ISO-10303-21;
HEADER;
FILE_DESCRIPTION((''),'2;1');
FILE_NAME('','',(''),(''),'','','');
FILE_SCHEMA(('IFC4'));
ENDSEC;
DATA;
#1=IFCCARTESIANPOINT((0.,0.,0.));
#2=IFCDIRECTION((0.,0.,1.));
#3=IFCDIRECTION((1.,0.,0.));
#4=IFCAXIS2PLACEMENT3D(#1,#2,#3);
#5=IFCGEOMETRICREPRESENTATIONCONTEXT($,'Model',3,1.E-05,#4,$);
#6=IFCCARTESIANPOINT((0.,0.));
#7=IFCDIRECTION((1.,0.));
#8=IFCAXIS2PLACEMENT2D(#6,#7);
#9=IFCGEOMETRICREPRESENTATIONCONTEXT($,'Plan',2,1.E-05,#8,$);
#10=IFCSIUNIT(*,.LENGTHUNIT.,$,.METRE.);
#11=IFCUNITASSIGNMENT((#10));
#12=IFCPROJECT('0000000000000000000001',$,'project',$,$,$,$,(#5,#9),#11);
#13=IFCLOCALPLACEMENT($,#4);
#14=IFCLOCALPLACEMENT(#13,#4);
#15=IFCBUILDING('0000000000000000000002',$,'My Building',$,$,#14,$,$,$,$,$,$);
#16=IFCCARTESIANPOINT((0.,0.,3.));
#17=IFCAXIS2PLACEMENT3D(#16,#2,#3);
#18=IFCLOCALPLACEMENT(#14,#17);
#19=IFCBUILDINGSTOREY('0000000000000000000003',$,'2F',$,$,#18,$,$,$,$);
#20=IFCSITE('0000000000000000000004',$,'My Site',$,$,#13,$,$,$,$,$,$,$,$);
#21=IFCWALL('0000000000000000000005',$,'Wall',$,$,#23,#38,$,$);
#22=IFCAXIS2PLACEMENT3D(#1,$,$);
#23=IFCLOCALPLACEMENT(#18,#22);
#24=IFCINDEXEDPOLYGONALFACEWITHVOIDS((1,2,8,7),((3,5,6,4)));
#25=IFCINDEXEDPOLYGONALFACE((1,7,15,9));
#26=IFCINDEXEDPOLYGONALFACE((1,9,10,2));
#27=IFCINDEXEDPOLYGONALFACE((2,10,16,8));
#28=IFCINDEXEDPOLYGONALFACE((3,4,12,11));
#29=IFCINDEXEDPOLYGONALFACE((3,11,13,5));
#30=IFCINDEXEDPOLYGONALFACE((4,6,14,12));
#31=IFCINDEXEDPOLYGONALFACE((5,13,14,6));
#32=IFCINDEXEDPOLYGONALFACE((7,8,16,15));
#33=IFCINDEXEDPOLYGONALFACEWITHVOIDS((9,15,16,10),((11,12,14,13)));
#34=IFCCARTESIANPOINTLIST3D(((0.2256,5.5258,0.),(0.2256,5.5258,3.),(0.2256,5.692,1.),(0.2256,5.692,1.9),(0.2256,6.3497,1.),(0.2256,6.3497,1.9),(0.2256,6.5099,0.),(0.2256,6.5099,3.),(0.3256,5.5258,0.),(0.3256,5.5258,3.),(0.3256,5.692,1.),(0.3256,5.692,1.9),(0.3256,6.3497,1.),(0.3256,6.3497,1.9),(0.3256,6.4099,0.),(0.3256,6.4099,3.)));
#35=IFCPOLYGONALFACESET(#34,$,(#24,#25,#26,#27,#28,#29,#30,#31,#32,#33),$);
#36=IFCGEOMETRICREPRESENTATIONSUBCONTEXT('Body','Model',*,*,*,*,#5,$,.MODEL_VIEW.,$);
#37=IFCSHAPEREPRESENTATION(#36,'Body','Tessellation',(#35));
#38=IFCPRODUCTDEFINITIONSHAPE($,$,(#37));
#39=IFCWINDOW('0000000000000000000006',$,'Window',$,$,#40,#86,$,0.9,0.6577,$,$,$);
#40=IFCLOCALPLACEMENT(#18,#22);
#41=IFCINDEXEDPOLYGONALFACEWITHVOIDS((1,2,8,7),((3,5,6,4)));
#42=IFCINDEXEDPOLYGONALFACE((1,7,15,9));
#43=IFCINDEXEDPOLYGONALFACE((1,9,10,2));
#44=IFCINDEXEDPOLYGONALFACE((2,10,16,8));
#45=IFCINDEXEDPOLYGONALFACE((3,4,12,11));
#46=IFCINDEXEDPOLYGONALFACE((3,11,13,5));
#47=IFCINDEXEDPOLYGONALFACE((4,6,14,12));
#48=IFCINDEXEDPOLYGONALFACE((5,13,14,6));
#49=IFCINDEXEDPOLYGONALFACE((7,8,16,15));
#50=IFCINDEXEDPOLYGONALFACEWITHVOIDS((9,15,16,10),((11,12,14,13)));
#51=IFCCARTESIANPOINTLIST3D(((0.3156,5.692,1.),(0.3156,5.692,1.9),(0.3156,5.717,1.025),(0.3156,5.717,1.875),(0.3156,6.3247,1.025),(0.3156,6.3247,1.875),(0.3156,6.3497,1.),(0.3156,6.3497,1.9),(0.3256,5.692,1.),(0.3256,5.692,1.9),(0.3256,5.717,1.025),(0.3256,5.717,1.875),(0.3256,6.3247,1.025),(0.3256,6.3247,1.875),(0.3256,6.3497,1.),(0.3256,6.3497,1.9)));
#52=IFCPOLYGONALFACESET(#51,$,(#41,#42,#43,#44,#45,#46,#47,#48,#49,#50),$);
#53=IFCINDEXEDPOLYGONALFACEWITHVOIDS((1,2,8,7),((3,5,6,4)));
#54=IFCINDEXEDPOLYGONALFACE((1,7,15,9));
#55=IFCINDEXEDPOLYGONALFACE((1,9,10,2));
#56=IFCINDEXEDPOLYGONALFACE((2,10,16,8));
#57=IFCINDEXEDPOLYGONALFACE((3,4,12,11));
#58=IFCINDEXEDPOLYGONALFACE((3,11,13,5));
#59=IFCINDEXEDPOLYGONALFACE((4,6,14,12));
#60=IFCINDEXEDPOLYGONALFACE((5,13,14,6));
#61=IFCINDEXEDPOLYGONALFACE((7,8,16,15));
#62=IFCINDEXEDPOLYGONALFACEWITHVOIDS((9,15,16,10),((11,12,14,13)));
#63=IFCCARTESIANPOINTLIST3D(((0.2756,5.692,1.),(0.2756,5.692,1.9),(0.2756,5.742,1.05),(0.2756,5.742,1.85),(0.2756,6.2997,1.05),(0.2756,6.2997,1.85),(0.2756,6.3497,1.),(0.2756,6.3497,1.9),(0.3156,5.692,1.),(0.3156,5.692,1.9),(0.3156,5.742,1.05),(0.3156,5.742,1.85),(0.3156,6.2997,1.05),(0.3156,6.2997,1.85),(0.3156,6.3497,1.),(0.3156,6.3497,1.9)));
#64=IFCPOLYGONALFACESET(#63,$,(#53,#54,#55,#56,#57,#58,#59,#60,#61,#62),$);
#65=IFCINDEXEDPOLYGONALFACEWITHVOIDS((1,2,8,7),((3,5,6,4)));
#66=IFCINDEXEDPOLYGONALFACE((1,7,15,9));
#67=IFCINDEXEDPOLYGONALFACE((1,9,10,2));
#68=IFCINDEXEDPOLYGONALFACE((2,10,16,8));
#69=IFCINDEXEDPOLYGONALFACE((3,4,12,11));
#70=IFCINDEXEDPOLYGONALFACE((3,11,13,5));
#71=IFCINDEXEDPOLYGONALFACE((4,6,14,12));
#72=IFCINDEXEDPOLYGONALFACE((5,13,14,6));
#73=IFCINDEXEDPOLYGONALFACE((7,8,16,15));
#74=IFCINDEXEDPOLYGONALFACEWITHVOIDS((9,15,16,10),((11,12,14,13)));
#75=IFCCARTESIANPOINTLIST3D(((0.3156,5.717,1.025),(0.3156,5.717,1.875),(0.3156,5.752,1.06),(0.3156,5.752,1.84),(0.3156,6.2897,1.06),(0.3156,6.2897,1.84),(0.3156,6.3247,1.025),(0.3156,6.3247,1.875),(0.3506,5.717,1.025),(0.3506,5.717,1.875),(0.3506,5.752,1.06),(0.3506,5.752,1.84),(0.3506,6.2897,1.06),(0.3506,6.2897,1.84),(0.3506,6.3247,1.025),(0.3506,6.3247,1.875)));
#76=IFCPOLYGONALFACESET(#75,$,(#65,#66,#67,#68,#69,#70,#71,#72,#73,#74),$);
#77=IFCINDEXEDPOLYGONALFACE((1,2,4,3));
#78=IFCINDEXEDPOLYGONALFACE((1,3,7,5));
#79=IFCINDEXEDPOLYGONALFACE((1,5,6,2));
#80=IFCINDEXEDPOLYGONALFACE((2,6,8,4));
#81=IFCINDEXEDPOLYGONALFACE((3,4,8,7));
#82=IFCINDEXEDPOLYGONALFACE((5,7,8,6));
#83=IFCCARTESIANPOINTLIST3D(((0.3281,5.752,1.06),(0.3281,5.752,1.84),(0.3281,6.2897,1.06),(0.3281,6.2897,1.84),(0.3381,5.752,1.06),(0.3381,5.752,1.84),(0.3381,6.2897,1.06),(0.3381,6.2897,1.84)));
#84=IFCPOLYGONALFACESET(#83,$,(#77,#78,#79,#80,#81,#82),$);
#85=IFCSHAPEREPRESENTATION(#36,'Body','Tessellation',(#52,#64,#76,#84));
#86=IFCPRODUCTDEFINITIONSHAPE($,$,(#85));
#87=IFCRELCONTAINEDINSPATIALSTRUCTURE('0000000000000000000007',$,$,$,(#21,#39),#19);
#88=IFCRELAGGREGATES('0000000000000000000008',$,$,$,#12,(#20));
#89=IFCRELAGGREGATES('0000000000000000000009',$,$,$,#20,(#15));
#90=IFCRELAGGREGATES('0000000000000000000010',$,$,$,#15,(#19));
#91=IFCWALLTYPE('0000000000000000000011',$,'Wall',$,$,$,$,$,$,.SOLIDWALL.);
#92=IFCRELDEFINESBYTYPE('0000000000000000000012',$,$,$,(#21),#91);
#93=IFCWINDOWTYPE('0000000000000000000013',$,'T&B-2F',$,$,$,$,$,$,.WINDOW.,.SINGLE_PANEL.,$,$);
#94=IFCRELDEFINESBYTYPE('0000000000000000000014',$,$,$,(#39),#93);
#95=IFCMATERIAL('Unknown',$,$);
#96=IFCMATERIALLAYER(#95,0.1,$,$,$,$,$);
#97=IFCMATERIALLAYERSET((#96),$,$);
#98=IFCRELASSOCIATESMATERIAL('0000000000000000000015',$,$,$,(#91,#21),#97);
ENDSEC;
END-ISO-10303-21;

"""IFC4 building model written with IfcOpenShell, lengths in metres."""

from ifc_helpers import new_model, entity, si_unit, frame, origin_with_axes, origin_2d_with_axis, place, context, subcontext, project, spatial, line, indexed_curve, outline, extrude, shape, source, transform, mapped, material, layer, layer_set, layer_usage, type_object, type_shapes, element, fill, save


model = new_model("IFC4")

# Units and contexts
model_context = context("Model", 3, precision=1e-05, world=origin_with_axes())
plan_context = context("Plan", 2, precision=1e-05, world=origin_2d_with_axis())
body_context_1 = subcontext(model_context, "Body", "Model", "MODEL_VIEW")
body_context_2 = subcontext(plan_context, "Body", "Plan", "PLAN_VIEW")
ifc_project = project(units=[si_unit("LENGTHUNIT", "METRE")], contexts=[model_context, plan_context])

# Site, building, storey
site_placement = place(None, origin_with_axes())
site = spatial("IfcSite", under=ifc_project, at=site_placement, Name="My Site")
building_placement = place(site_placement, origin_with_axes())
building = spatial("IfcBuilding", under=site, at=building_placement, Name="My Building")
storey_placement = place(building_placement, frame((0.0, 0.0, 3.0), z_axis=(0.0, 0.0, 1.0), x_axis=(1.0, 0.0, 0.0)))
storey = spatial("IfcBuildingStorey", under=building, at=storey_placement, Name="2F")

# Shared definitions
ifc_material = material(Name="Unknown")

# Shared definitions
ifc_layer = layer(ifc_material, 0.1)
ifc_layer_set = layer_set([ifc_layer])
wall_type = type_object("IfcWallType", Name="Wall", PredefinedType="SOLIDWALL", material=ifc_layer_set)

# Wall, opening, window
ifc_layer_usage_1 = layer_usage(ifc_layer_set, "AXIS2", "POSITIVE", 0.0)
wall_1_placement = place(storey_placement, frame((0.2256, 6.5099, 0.0), z_axis=(0.0, 0.0, 1.0), x_axis=(0.0, -1.0, 0.0)))
wall_1 = element("IfcWall", 1, at=wall_1_placement, inside=storey, type_object=wall_type, material=ifc_layer_usage_1, Name="Wall", context=body_context_1, shape_type="SweptSolid", body=[
    extrude(outline(indexed_curve([(0.0, 0.0), (0.1, 0.1), (0.9842, 0.1), (0.9842, 0.0)], segments=[line(1, 2, 3, 4, 1)])), origin_with_axes(), (0.0, 0.0, 1.0), 3.0),
])
shared_shape_1 = source(origin_with_axes(), body_context_1, "Body", "SweptSolid", [
    extrude(outline(indexed_curve([(0.0, 0.0), (0.6577, 0.0), (0.6577, 0.9), (0.0, 0.9)], segments=[line(1, 2, 3, 4, 1)])), frame((0.0, -0.6, 0.0), z_axis=(0.0, -1.0, 0.0), x_axis=(1.0, 0.0, 0.0)), (0.0, 0.0, -1.0), 1.2),
])
opening_1_placement = place(wall_1_placement, frame((0.1602, 0.0, 1.0), z_axis=(0.0, 0.0, 1.0), x_axis=(1.0, 0.0, 0.0)))
opening_1 = element("IfcOpeningElement", 2, at=opening_1_placement, cuts=wall_1, PredefinedType="OPENING", context=body_context_1, shape_type="MappedRepresentation", body=[
    mapped(shared_shape_1, transform((0.0, 0.0, 0.0), x_axis=(1.0, 0.0, 0.0), y_axis=(0.0, 1.0, 0.0), z_axis=(0.0, 0.0, 1.0), scale=1.0)),
])
window_type_1 = type_object("IfcWindowType", Name="T&B-2F", PartitioningType="SINGLE_PANEL", PredefinedType="WINDOW")
shared_shape_2 = source(origin_with_axes(), body_context_1, "Body", "SweptSolid", [
    extrude(outline(indexed_curve([(0.0, 0.0), (0.6577, 0.0), (0.6577, 0.9), (0.0, 0.9)], segments=[line(1, 2, 3, 4, 1)]), holes=[indexed_curve([(0.025, 0.025), (0.6327, 0.025), (0.6327, 0.875), (0.025, 0.875)], segments=[line(1, 2, 3, 4, 1)])]), frame((0.0, 0.09, 0.0), z_axis=(0.0, -1.0, 0.0), x_axis=(1.0, 0.0, 0.0)), (0.0, 0.0, -1.0), 0.01),
    extrude(outline(indexed_curve([(0.0, 0.0), (0.6577, 0.0), (0.6577, 0.9), (0.0, 0.9)], segments=[line(1, 2, 3, 4, 1)]), holes=[indexed_curve([(0.05, 0.05), (0.6077, 0.05), (0.6077, 0.85), (0.05, 0.85)], segments=[line(1, 2, 3, 4, 1)])]), frame((0.0, 0.05, 0.0), z_axis=(0.0, -1.0, 0.0), x_axis=(1.0, 0.0, 0.0)), (0.0, 0.0, -1.0), 0.04),
    extrude(outline(indexed_curve([(0.0, 0.0), (0.6077, 0.0), (0.6077, 0.85), (0.0, 0.85)], segments=[line(1, 2, 3, 4, 1)]), holes=[indexed_curve([(0.035, 0.035), (0.5727, 0.035), (0.5727, 0.815), (0.035, 0.815)], segments=[line(1, 2, 3, 4, 1)])]), frame((0.025, 0.09, 0.025), z_axis=(0.0, -1.0, 0.0), x_axis=(1.0, 0.0, 0.0)), (0.0, 0.0, -1.0), 0.035),
    extrude(outline(indexed_curve([(0.035, 0.035), (0.5727, 0.035), (0.5727, 0.815), (0.035, 0.815)], segments=[line(1, 2, 3, 4, 1)])), frame((0.025, 0.1025, 0.025), z_axis=(0.0, -1.0, 0.0), x_axis=(1.0, 0.0, 0.0)), (0.0, 0.0, -1.0), 0.01),
])
shared_shape_3 = source(origin_with_axes(), body_context_2, "Body", "Curve2D", [
    entity("IfcIndexedPolyCurve", entity("IfcCartesianPointList2D", [[0.05, 0.05], [0.6077, 0.05]])),
    entity("IfcIndexedPolyCurve", entity("IfcCartesianPointList2D", [[0.0, 0.1], [0.025, 0.1], [0.025, 0.09], [0.05, 0.09], [0.05, 0.05], [0.0, 0.05]]), [entity("IfcLineIndex", [1, 2, 3, 4, 5, 6, 1])]),
    entity("IfcIndexedPolyCurve", entity("IfcCartesianPointList2D", [[0.6577, 0.1], [0.6327, 0.1], [0.6327, 0.09], [0.6077, 0.09], [0.6077, 0.05], [0.6577, 0.05]]), [entity("IfcLineIndex", [1, 2, 3, 4, 5, 6, 1])]),
    entity("IfcIndexedPolyCurve", entity("IfcCartesianPointList2D", [[0.025, 0.09], [0.06, 0.09], [0.06, 0.125], [0.025, 0.125]]), [entity("IfcLineIndex", [1, 2, 3, 4, 1])]),
    entity("IfcIndexedPolyCurve", entity("IfcCartesianPointList2D", [[0.6327, 0.09], [0.5977, 0.09], [0.5977, 0.125], [0.6327, 0.125]]), [entity("IfcLineIndex", [1, 2, 3, 4, 1])]),
    entity("IfcIndexedPolyCurve", entity("IfcCartesianPointList2D", [[0.06, 0.09], [0.5977, 0.09]])),
    entity("IfcIndexedPolyCurve", entity("IfcCartesianPointList2D", [[0.06, 0.125], [0.5977, 0.125]])),
    entity("IfcIndexedPolyCurve", entity("IfcCartesianPointList2D", [[0.06, 0.1075], [0.5977, 0.1075]])),
])
type_shapes(window_type_1, [shared_shape_2, shared_shape_3])
window_1_placement = place(opening_1_placement, frame((0.0, 0.0, 0.0), z_axis=(0.0, 0.0, 1.0), x_axis=(1.0, 0.0, 0.0)))
window_1 = element("IfcWindow", 3, at=window_1_placement, inside=storey, type_object=window_type_1, Name="Window", OverallHeight=0.9, OverallWidth=0.6577, shapes=[
    shape(body_context_1, "Body", "MappedRepresentation", [mapped(shared_shape_2, transform((0.0, 0.0, 0.0), x_axis=(1.0, 0.0, 0.0), y_axis=(0.0, 1.0, 0.0), z_axis=(0.0, 0.0, 1.0), scale=1.0))]),
    shape(body_context_2, "Body", "MappedRepresentation", [mapped(shared_shape_3, transform((0.0, 0.0, 0.0), x_axis=(1.0, 0.0, 0.0), y_axis=(0.0, 1.0, 0.0), z_axis=(0.0, 0.0, 1.0), scale=1.0))]),
])
fill(opening_1, window_1)

save(model, "model.ifc")
